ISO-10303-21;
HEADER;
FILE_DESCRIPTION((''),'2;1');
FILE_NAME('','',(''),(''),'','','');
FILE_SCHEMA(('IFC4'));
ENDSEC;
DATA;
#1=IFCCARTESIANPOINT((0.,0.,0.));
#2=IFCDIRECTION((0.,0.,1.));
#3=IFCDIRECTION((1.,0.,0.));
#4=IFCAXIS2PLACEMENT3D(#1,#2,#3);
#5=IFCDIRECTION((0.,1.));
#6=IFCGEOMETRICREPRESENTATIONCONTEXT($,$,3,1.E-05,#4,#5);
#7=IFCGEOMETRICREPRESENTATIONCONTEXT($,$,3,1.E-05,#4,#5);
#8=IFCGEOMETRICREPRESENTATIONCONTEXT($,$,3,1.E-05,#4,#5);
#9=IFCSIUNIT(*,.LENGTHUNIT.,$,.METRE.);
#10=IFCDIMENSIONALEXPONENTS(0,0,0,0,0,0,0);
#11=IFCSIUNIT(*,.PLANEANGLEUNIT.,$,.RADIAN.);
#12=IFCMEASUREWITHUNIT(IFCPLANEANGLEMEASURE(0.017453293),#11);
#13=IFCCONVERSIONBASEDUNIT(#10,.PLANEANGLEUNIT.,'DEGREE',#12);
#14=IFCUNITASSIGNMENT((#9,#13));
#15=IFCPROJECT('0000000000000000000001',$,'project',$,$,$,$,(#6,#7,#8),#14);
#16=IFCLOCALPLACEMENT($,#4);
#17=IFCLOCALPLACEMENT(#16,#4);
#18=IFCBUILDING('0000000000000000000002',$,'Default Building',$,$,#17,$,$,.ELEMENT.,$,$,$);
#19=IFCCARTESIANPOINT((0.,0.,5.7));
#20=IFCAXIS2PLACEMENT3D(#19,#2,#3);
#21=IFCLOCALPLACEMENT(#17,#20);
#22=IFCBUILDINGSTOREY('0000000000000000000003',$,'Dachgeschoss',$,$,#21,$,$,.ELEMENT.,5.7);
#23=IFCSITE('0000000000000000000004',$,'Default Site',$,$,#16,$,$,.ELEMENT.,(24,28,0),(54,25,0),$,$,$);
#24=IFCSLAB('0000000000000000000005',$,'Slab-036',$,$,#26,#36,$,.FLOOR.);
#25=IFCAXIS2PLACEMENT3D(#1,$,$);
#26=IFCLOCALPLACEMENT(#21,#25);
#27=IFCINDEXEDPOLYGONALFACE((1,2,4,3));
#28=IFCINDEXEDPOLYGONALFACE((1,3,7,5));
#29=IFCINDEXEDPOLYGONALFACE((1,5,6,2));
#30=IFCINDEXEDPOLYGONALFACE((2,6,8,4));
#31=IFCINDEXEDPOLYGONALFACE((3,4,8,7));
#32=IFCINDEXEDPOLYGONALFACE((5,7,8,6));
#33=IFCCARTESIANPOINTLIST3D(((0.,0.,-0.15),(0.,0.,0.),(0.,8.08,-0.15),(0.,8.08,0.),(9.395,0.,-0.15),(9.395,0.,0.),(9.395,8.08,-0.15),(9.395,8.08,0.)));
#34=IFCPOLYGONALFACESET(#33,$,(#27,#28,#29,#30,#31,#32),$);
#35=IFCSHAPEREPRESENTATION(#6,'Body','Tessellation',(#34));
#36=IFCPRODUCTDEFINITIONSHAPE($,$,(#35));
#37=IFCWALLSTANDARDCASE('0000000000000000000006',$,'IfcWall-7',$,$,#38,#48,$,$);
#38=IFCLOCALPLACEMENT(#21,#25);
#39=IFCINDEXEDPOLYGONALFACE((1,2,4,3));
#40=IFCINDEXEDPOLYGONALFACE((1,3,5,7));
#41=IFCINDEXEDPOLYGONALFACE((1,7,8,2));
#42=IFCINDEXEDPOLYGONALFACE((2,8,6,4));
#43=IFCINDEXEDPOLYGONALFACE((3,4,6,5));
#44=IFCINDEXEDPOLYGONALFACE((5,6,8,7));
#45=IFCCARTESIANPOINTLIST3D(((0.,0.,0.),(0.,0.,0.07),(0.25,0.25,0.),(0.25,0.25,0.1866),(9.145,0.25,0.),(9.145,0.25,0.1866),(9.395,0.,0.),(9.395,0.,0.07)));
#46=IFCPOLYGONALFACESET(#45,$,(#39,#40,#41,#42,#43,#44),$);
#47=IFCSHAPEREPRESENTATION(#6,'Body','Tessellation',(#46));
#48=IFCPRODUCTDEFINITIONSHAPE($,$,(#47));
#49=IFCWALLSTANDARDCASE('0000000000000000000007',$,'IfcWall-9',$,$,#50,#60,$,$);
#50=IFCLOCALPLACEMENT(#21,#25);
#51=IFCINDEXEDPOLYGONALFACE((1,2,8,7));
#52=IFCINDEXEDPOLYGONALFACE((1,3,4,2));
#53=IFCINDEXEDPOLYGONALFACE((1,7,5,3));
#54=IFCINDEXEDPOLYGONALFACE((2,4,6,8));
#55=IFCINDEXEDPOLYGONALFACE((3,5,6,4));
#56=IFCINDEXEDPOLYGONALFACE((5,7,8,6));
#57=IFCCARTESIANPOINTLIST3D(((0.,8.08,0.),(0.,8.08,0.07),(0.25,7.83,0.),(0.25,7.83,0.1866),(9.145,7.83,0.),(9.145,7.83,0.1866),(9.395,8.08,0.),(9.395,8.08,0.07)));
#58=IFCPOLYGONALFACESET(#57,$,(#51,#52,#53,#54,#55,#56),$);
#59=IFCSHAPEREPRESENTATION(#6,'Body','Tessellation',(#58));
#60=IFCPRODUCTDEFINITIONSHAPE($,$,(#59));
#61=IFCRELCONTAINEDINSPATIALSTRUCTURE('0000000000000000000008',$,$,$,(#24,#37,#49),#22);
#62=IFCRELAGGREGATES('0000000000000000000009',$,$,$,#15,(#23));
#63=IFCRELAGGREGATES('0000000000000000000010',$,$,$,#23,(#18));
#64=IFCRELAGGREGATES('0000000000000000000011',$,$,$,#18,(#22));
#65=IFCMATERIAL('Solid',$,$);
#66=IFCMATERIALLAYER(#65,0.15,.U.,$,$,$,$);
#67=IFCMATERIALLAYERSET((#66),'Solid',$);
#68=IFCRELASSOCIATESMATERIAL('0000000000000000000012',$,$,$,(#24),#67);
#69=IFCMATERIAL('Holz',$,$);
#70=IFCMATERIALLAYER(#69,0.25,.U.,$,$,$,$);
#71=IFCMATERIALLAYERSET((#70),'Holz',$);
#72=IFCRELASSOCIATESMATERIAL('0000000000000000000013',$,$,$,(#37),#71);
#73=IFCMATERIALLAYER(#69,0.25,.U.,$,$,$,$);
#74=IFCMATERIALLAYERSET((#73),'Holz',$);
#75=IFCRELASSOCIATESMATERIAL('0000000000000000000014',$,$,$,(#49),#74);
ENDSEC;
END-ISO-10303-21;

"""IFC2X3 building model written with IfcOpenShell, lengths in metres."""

from ifc_helpers import new_model, entity, si_unit, converted_unit, direction, frame, origin_with_axes, place, context, project, spatial, polyline, outline, extrude, clip, halfspace, material, layer, layer_set, layer_usage, element, save


model = new_model("IFC2X3")

# Units and contexts
context_of_model_1 = context(None, 3, precision=1e-05, world=origin_with_axes(), true_north=direction((0.0, 1.0)))
context_of_model_2 = context(None, 3, precision=1e-05, world=origin_with_axes(), true_north=direction((0.0, 1.0)))
context_of_model_3 = context(None, 3, precision=1e-05, world=origin_with_axes(), true_north=direction((0.0, 1.0)))
ifc_project = project(units=[si_unit("LENGTHUNIT", "METRE"), converted_unit("PLANEANGLEUNIT", "DEGREE", entity("IfcPlaneAngleMeasure", 0.017453293), si_unit("PLANEANGLEUNIT", "RADIAN"), dimensions=[0, 0, 0, 0, 0, 0, 0])], contexts=[context_of_model_1, context_of_model_2, context_of_model_3])

# Site, building, storey
site_placement = place(None, origin_with_axes())
site = spatial("IfcSite", under=ifc_project, at=site_placement, Name="Default Site", CompositionType="ELEMENT", RefLatitude=(24, 28, 0), RefLongitude=(54, 25, 0))
building_placement = place(site_placement, origin_with_axes())
building = spatial("IfcBuilding", under=site, at=building_placement, Name="Default Building", CompositionType="ELEMENT")
storey_placement = place(building_placement, frame((0.0, 0.0, 5.7), z_axis=(0.0, 0.0, 1.0), x_axis=(1.0, 0.0, 0.0)))
storey = spatial("IfcBuildingStorey", under=building, at=storey_placement, Name="Dachgeschoss", CompositionType="ELEMENT", Elevation=5.7)

# Slab
ifc_material_1 = material(Name="Solid")
ifc_layer_1 = layer(ifc_material_1, 0.15, ventilated="UNKNOWN")
ifc_layer_set_1 = layer_set([ifc_layer_1], Name="Solid")
ifc_layer_usage_1 = layer_usage(ifc_layer_set_1, "AXIS3", "NEGATIVE", 0.15)
slab_1_placement = place(storey_placement, frame((0.0, 0.0, -0.15), z_axis=(0.0, 0.0, 1.0), x_axis=(1.0, 0.0, 0.0)))
element("IfcSlab", 1, at=slab_1_placement, inside=storey, material=ifc_layer_usage_1, Name="Slab-036", PredefinedType="FLOOR", context=context_of_model_1, shape_type="SweptSolid", body=[
    extrude(outline(polyline([(0.0, 0.0), (9.395, 0.0), (9.395, 8.08), (0.0, 8.08), (0.0, 0.0)])), origin_with_axes(), (0.0, 0.0, 1.0), 0.15),
])

# Walls
ifc_material_2 = material(Name="Holz")
ifc_layer_2 = layer(ifc_material_2, 0.25, ventilated="UNKNOWN")
ifc_layer_set_2 = layer_set([ifc_layer_2], Name="Holz")
ifc_layer_usage_2 = layer_usage(ifc_layer_set_2, "AXIS2", "POSITIVE", 0.0)
wall_1_placement = place(storey_placement, frame((0.0, 0.0, 0.0), z_axis=(0.0, 0.0, 1.0), x_axis=(1.0, 0.0, 0.0)))
element("IfcWallStandardCase", 2, at=wall_1_placement, inside=storey, material=ifc_layer_usage_2, Name="IfcWall-7", context=context_of_model_1, shape_type="Clipping", body=[
    clip(extrude(outline(polyline([(0.0, 0.0), (9.395, 0.0), (9.145, 0.25), (0.25, 0.25), (0.0, 0.0)])), origin_with_axes(), (0.0, 0.0, 1.0), 2.7), halfspace(frame((0.0, -0.0268, 0.0575), z_axis=(0.0, -0.422618, 0.906308), x_axis=(0.0, 0.906308, 0.422618)), False)),
])
ifc_layer_3 = layer(ifc_material_2, 0.25, ventilated="UNKNOWN")
ifc_layer_set_3 = layer_set([ifc_layer_3], Name="Holz")
ifc_layer_usage_3 = layer_usage(ifc_layer_set_3, "AXIS2", "POSITIVE", 0.0)
wall_2_placement = place(storey_placement, frame((9.395, 8.08, 0.0), z_axis=(0.0, 0.0, 1.0), x_axis=(-1.0, 0.0, 0.0)))
element("IfcWallStandardCase", 3, at=wall_2_placement, inside=storey, material=ifc_layer_usage_3, Name="IfcWall-9", context=context_of_model_1, shape_type="Clipping", body=[
    clip(extrude(outline(polyline([(0.0, 0.0), (9.395, 0.0), (9.145, 0.25), (0.25, 0.25), (0.0, 0.0)])), origin_with_axes(), (0.0, 0.0, 1.0), 2.7), halfspace(frame((0.0, -0.0268, 0.0575), z_axis=(0.0, -0.422618, 0.906308), x_axis=(0.0, 0.906308, 0.422618)), False)),
])

save(model, "model.ifc")
